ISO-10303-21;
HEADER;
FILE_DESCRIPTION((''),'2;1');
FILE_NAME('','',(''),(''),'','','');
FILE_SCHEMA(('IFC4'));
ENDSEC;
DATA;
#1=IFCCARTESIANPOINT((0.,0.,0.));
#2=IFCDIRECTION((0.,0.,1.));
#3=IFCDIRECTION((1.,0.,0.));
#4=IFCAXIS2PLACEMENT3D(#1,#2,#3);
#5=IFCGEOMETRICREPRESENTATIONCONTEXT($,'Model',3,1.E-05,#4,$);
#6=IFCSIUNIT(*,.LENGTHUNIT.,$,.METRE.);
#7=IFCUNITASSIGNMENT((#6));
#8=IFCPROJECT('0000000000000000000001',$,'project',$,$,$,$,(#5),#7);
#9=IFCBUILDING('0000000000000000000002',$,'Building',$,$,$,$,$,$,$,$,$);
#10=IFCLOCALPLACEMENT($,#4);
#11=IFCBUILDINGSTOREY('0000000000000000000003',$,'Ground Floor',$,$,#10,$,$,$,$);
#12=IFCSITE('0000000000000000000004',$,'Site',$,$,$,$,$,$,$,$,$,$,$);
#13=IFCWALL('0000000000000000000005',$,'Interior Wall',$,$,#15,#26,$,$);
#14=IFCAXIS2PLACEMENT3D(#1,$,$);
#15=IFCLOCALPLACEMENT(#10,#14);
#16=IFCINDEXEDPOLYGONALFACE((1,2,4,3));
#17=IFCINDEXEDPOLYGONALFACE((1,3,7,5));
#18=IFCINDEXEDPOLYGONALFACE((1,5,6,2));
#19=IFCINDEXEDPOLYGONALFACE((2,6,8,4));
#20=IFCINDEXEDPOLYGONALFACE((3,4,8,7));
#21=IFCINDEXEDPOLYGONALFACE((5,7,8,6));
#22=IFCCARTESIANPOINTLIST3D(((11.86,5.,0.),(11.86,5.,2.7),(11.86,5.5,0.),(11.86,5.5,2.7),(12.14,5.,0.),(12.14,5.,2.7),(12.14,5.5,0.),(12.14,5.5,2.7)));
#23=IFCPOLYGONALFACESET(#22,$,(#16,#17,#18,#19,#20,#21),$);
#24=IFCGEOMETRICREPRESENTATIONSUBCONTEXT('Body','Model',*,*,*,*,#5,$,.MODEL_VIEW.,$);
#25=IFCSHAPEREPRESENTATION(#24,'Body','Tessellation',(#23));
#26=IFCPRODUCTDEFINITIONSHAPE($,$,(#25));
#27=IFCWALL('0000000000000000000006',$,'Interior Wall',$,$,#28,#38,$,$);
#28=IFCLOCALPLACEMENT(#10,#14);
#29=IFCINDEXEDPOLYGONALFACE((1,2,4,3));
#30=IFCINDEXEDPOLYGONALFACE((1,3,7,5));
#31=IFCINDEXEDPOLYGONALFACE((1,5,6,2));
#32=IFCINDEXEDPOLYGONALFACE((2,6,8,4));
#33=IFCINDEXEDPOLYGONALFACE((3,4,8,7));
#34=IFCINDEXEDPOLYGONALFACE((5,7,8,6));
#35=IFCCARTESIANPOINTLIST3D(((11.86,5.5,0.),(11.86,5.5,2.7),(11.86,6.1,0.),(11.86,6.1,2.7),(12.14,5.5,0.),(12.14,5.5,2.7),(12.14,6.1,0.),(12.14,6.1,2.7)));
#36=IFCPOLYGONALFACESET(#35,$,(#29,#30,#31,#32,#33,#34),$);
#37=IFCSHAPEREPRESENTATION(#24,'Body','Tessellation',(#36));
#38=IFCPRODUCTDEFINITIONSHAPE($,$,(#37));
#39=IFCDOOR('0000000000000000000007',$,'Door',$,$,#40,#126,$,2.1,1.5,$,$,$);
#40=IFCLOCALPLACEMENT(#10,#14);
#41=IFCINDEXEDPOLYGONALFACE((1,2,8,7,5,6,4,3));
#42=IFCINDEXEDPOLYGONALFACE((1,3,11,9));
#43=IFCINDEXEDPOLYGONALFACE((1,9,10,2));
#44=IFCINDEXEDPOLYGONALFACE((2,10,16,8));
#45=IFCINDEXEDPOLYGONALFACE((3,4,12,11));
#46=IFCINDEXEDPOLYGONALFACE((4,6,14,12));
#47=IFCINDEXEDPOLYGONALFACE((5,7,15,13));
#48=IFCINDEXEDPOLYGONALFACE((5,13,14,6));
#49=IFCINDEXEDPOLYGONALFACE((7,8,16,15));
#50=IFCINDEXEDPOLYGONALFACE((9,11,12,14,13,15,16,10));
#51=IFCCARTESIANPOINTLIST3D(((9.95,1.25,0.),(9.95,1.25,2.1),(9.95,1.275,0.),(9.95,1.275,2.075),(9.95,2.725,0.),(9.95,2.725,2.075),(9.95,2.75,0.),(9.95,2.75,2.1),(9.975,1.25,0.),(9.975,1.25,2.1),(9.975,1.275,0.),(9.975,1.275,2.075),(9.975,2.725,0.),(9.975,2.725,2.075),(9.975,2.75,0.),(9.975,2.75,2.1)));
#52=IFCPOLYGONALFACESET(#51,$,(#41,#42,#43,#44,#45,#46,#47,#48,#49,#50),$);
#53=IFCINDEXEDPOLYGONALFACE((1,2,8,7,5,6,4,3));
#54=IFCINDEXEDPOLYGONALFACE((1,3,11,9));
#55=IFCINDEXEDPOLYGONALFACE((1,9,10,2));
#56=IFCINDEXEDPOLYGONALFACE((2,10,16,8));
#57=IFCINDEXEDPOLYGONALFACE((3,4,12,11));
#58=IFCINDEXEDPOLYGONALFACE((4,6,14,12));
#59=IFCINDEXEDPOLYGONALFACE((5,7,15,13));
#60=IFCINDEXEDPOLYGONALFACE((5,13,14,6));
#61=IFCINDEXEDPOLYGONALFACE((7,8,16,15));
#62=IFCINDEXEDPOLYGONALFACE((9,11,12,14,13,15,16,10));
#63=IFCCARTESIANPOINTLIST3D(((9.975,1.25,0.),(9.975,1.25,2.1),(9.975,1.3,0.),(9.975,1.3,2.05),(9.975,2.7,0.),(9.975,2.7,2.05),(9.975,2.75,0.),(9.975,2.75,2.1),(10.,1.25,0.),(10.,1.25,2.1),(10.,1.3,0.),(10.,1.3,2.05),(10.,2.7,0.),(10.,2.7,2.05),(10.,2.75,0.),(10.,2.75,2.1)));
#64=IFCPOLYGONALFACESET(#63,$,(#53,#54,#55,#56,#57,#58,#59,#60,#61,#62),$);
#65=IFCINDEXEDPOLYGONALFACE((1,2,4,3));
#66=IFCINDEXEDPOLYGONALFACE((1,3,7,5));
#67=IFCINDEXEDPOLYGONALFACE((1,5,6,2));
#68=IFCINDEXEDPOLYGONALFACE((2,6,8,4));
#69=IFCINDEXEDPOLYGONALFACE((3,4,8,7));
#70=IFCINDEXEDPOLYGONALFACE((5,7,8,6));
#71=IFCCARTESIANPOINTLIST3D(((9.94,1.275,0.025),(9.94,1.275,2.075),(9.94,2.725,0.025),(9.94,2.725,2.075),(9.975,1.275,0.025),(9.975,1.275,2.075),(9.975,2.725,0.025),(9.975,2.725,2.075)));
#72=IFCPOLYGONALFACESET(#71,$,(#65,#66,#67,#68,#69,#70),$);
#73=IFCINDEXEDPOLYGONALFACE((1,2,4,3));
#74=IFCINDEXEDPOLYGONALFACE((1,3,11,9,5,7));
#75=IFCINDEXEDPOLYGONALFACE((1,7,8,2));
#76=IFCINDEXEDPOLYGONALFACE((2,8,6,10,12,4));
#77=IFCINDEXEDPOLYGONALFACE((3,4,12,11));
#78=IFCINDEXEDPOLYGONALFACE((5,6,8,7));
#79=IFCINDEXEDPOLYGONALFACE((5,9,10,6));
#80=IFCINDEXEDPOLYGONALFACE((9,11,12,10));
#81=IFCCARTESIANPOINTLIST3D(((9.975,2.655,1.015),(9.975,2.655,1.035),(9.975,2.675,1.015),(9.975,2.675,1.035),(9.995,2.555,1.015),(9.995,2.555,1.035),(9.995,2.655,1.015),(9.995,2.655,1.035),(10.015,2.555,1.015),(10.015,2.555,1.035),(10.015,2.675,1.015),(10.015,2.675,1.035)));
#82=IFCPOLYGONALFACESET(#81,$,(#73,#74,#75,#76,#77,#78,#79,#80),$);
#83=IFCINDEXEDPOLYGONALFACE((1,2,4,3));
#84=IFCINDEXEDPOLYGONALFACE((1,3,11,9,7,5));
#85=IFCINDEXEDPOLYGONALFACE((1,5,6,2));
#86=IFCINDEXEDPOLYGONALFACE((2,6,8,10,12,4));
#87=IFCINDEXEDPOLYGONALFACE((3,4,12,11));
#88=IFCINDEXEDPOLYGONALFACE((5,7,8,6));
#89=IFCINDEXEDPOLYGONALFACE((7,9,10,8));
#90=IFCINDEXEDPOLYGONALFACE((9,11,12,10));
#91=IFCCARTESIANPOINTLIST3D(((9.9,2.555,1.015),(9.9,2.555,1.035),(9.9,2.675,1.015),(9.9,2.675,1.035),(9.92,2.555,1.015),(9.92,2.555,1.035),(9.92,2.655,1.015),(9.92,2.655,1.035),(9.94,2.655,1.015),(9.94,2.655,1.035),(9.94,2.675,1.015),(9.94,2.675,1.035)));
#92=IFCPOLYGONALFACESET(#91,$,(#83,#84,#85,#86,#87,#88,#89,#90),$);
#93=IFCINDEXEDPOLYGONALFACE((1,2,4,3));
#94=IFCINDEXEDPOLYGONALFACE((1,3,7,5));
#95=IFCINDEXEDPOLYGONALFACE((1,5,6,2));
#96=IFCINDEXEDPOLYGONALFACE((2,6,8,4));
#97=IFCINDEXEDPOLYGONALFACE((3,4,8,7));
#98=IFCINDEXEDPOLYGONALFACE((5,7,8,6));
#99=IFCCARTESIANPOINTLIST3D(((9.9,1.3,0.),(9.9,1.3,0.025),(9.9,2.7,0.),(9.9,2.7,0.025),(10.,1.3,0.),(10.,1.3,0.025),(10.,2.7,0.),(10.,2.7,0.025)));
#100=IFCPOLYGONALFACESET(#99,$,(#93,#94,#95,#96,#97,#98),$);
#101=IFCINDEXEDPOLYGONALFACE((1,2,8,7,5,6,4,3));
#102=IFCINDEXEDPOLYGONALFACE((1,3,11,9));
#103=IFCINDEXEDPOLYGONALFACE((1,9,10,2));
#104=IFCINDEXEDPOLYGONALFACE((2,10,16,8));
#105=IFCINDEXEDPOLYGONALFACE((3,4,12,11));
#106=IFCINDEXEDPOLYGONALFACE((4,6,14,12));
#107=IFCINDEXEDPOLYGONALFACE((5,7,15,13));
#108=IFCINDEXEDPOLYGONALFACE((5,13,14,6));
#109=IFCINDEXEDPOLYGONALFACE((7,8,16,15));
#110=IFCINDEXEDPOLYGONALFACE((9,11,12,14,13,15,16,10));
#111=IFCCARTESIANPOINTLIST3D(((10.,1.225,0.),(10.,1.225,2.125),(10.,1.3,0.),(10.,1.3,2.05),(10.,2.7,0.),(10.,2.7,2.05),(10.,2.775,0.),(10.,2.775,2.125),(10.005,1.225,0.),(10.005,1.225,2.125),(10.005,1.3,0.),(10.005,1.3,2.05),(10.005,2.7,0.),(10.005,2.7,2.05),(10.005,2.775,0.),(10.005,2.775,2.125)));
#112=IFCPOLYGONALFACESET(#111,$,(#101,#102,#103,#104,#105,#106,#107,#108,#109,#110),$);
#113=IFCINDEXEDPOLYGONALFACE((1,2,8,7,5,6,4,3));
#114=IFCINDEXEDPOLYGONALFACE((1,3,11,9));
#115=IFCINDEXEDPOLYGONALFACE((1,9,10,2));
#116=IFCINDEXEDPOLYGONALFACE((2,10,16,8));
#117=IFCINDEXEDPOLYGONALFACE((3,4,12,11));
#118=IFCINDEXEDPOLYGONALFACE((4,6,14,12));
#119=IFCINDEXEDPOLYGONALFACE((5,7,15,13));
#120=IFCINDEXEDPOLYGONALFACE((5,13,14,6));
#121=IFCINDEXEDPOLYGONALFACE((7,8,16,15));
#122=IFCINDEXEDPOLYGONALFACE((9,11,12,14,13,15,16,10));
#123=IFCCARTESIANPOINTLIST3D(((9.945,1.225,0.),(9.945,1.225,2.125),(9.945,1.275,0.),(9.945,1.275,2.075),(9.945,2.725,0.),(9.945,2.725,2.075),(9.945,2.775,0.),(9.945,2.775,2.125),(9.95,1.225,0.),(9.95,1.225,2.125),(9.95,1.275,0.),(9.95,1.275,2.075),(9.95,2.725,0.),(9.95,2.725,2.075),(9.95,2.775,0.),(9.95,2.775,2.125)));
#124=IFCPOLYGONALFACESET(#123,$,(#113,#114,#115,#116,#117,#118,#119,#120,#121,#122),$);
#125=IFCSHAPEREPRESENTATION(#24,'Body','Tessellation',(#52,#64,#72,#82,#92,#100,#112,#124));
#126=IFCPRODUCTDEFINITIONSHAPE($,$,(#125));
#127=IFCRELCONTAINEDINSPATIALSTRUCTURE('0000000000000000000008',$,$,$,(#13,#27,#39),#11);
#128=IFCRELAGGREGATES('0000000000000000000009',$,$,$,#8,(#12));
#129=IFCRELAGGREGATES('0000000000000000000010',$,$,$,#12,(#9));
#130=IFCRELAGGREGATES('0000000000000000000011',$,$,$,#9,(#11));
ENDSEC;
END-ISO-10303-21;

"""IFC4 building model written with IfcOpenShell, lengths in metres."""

from ifc_helpers import new_model, si_unit, frame, origin_with_axes, place, context, subcontext, project, spatial, line, indexed_curve, outline, extrude, element, save


model = new_model("IFC4")

# Units and contexts
model_context = context("Model", 3, precision=1e-05, world=origin_with_axes())
body_context = subcontext(model_context, "Body", "Model", "MODEL_VIEW")
ifc_project = project(units=[si_unit("LENGTHUNIT", "METRE")], contexts=[model_context])

# Site, building, storey
site = spatial("IfcSite", under=ifc_project, Name="Site")
building = spatial("IfcBuilding", under=site, Name="Building")
storey_placement = place(None, origin_with_axes())
storey = spatial("IfcBuildingStorey", under=building, at=storey_placement, Name="Ground Floor")

# Walls
wall_1_placement = place(storey_placement, frame((12.0, 5.5, 0.0), z_axis=(0.0, 0.0, 1.0), x_axis=(0.0, -1.0, 0.0)))
element("IfcWall", 1, at=wall_1_placement, inside=storey, Name="Interior Wall", context=body_context, shape_type="SweptSolid", body=[
    extrude(outline(indexed_curve([(0.0, 0.0), (0.0, 0.28), (0.5, 0.28), (0.5, 0.0), (0.0, 0.0)], self_intersect=False)), frame((0.0, -0.14, 0.0), z_axis=(0.0, 0.0, 1.0), x_axis=(1.0, 0.0, 0.0)), (0.0, 0.0, 1.0), 2.7),
])
wall_2_placement = place(storey_placement, frame((12.0, 5.5, 0.0), z_axis=(0.0, 0.0, 1.0), x_axis=(0.0, 1.0, 0.0)))
element("IfcWall", 2, at=wall_2_placement, inside=storey, Name="Interior Wall", context=body_context, shape_type="SweptSolid", body=[
    extrude(outline(indexed_curve([(0.0, 0.0), (0.0, 0.28), (0.6, 0.28), (0.6, 0.0), (0.0, 0.0)], self_intersect=False)), frame((0.0, -0.14, 0.0), z_axis=(0.0, 0.0, 1.0), x_axis=(1.0, 0.0, 0.0)), (0.0, 0.0, 1.0), 2.7),
])

# Door
door_1_placement = place(storey_placement, frame((10.0, 1.25, 0.0), z_axis=(0.0, 0.0, 1.0), x_axis=(0.0, 1.0, 0.0)))
element("IfcDoor", 3, at=door_1_placement, inside=storey, Name="Door", OverallHeight=2.1, OverallWidth=1.5, context=body_context, shape_type="SweptSolid", body=[
    extrude(outline(indexed_curve([(0.0, 0.0), (0.0, 2.1), (1.5, 2.1), (1.5, 0.0), (1.475, 0.0), (1.475, 2.075), (0.025, 2.075), (0.025, 0.0)], segments=[line(1, 2, 3, 4, 5, 6, 7, 8, 1)])), frame((0.0, 0.025, 0.0), z_axis=(0.0, -1.0, 0.0), x_axis=(1.0, 0.0, 0.0)), (0.0, 0.0, -1.0), 0.025),
    extrude(outline(indexed_curve([(0.0, 0.0), (0.0, 2.1), (1.5, 2.1), (1.5, 0.0), (1.45, 0.0), (1.45, 2.05), (0.05, 2.05), (0.05, 0.0)], segments=[line(1, 2, 3, 4, 5, 6, 7, 8, 1)])), frame((0.0, 0.0, 0.0), z_axis=(0.0, -1.0, 0.0), x_axis=(1.0, 0.0, 0.0)), (0.0, 0.0, -1.0), 0.025),
    extrude(outline(indexed_curve([(0.0, 0.0), (1.45, 0.0), (1.45, 0.035), (0.0, 0.035)], segments=[line(1, 2, 3, 4, 1)])), frame((0.025, 0.025, 0.025), z_axis=(0.0, 0.0, 1.0), x_axis=(1.0, 0.0, 0.0)), (0.0, 0.0, 1.0), 2.05),
    extrude(outline(indexed_curve([(0.0, 0.0), (0.0, -0.04), (-0.12, -0.04), (-0.12, -0.02), (-0.02, -0.02), (-0.02, 0.0)], segments=[line(1, 2, 3, 4, 5, 6, 1)])), frame((1.425, 0.025, 1.015), z_axis=(0.0, 0.0, 1.0), x_axis=(1.0, 0.0, 0.0)), (0.0, 0.0, 1.0), 0.02),
    extrude(outline(indexed_curve([(0.0, 0.0), (0.0, 0.04), (-0.12, 0.04), (-0.12, 0.02), (-0.02, 0.02), (-0.02, 0.0)], segments=[line(1, 2, 3, 4, 5, 6, 1)])), frame((1.425, 0.06, 1.015), z_axis=(0.0, 0.0, 1.0), x_axis=(1.0, 0.0, 0.0)), (0.0, 0.0, 1.0), 0.02),
    extrude(outline(indexed_curve([(0.0, 0.0), (1.4, 0.0), (1.4, 0.1), (0.0, 0.1)], segments=[line(1, 2, 3, 4, 1)])), frame((0.05, 0.0, 0.0), z_axis=(0.0, 0.0, 1.0), x_axis=(1.0, 0.0, 0.0)), (0.0, 0.0, 1.0), 0.025),
    extrude(outline(indexed_curve([(0.0, 0.0), (0.0, 2.125), (1.55, 2.125), (1.55, 0.0), (1.475, 0.0), (1.475, 2.05), (0.075, 2.05), (0.075, 0.0)], segments=[line(1, 2, 3, 4, 5, 6, 7, 8, 1)])), frame((-0.025, -0.005, 0.0), z_axis=(0.0, -1.0, 0.0), x_axis=(1.0, 0.0, 0.0)), (0.0, 0.0, -1.0), 0.005),
    extrude(outline(indexed_curve([(0.0, 0.0), (0.0, 2.125), (1.55, 2.125), (1.55, 0.0), (1.5, 0.0), (1.5, 2.075), (0.05, 2.075), (0.05, 0.0)], segments=[line(1, 2, 3, 4, 5, 6, 7, 8, 1)])), frame((-0.025, 0.05, 0.0), z_axis=(0.0, -1.0, 0.0), x_axis=(1.0, 0.0, 0.0)), (0.0, 0.0, -1.0), 0.005),
])

save(model, "model.ifc")
